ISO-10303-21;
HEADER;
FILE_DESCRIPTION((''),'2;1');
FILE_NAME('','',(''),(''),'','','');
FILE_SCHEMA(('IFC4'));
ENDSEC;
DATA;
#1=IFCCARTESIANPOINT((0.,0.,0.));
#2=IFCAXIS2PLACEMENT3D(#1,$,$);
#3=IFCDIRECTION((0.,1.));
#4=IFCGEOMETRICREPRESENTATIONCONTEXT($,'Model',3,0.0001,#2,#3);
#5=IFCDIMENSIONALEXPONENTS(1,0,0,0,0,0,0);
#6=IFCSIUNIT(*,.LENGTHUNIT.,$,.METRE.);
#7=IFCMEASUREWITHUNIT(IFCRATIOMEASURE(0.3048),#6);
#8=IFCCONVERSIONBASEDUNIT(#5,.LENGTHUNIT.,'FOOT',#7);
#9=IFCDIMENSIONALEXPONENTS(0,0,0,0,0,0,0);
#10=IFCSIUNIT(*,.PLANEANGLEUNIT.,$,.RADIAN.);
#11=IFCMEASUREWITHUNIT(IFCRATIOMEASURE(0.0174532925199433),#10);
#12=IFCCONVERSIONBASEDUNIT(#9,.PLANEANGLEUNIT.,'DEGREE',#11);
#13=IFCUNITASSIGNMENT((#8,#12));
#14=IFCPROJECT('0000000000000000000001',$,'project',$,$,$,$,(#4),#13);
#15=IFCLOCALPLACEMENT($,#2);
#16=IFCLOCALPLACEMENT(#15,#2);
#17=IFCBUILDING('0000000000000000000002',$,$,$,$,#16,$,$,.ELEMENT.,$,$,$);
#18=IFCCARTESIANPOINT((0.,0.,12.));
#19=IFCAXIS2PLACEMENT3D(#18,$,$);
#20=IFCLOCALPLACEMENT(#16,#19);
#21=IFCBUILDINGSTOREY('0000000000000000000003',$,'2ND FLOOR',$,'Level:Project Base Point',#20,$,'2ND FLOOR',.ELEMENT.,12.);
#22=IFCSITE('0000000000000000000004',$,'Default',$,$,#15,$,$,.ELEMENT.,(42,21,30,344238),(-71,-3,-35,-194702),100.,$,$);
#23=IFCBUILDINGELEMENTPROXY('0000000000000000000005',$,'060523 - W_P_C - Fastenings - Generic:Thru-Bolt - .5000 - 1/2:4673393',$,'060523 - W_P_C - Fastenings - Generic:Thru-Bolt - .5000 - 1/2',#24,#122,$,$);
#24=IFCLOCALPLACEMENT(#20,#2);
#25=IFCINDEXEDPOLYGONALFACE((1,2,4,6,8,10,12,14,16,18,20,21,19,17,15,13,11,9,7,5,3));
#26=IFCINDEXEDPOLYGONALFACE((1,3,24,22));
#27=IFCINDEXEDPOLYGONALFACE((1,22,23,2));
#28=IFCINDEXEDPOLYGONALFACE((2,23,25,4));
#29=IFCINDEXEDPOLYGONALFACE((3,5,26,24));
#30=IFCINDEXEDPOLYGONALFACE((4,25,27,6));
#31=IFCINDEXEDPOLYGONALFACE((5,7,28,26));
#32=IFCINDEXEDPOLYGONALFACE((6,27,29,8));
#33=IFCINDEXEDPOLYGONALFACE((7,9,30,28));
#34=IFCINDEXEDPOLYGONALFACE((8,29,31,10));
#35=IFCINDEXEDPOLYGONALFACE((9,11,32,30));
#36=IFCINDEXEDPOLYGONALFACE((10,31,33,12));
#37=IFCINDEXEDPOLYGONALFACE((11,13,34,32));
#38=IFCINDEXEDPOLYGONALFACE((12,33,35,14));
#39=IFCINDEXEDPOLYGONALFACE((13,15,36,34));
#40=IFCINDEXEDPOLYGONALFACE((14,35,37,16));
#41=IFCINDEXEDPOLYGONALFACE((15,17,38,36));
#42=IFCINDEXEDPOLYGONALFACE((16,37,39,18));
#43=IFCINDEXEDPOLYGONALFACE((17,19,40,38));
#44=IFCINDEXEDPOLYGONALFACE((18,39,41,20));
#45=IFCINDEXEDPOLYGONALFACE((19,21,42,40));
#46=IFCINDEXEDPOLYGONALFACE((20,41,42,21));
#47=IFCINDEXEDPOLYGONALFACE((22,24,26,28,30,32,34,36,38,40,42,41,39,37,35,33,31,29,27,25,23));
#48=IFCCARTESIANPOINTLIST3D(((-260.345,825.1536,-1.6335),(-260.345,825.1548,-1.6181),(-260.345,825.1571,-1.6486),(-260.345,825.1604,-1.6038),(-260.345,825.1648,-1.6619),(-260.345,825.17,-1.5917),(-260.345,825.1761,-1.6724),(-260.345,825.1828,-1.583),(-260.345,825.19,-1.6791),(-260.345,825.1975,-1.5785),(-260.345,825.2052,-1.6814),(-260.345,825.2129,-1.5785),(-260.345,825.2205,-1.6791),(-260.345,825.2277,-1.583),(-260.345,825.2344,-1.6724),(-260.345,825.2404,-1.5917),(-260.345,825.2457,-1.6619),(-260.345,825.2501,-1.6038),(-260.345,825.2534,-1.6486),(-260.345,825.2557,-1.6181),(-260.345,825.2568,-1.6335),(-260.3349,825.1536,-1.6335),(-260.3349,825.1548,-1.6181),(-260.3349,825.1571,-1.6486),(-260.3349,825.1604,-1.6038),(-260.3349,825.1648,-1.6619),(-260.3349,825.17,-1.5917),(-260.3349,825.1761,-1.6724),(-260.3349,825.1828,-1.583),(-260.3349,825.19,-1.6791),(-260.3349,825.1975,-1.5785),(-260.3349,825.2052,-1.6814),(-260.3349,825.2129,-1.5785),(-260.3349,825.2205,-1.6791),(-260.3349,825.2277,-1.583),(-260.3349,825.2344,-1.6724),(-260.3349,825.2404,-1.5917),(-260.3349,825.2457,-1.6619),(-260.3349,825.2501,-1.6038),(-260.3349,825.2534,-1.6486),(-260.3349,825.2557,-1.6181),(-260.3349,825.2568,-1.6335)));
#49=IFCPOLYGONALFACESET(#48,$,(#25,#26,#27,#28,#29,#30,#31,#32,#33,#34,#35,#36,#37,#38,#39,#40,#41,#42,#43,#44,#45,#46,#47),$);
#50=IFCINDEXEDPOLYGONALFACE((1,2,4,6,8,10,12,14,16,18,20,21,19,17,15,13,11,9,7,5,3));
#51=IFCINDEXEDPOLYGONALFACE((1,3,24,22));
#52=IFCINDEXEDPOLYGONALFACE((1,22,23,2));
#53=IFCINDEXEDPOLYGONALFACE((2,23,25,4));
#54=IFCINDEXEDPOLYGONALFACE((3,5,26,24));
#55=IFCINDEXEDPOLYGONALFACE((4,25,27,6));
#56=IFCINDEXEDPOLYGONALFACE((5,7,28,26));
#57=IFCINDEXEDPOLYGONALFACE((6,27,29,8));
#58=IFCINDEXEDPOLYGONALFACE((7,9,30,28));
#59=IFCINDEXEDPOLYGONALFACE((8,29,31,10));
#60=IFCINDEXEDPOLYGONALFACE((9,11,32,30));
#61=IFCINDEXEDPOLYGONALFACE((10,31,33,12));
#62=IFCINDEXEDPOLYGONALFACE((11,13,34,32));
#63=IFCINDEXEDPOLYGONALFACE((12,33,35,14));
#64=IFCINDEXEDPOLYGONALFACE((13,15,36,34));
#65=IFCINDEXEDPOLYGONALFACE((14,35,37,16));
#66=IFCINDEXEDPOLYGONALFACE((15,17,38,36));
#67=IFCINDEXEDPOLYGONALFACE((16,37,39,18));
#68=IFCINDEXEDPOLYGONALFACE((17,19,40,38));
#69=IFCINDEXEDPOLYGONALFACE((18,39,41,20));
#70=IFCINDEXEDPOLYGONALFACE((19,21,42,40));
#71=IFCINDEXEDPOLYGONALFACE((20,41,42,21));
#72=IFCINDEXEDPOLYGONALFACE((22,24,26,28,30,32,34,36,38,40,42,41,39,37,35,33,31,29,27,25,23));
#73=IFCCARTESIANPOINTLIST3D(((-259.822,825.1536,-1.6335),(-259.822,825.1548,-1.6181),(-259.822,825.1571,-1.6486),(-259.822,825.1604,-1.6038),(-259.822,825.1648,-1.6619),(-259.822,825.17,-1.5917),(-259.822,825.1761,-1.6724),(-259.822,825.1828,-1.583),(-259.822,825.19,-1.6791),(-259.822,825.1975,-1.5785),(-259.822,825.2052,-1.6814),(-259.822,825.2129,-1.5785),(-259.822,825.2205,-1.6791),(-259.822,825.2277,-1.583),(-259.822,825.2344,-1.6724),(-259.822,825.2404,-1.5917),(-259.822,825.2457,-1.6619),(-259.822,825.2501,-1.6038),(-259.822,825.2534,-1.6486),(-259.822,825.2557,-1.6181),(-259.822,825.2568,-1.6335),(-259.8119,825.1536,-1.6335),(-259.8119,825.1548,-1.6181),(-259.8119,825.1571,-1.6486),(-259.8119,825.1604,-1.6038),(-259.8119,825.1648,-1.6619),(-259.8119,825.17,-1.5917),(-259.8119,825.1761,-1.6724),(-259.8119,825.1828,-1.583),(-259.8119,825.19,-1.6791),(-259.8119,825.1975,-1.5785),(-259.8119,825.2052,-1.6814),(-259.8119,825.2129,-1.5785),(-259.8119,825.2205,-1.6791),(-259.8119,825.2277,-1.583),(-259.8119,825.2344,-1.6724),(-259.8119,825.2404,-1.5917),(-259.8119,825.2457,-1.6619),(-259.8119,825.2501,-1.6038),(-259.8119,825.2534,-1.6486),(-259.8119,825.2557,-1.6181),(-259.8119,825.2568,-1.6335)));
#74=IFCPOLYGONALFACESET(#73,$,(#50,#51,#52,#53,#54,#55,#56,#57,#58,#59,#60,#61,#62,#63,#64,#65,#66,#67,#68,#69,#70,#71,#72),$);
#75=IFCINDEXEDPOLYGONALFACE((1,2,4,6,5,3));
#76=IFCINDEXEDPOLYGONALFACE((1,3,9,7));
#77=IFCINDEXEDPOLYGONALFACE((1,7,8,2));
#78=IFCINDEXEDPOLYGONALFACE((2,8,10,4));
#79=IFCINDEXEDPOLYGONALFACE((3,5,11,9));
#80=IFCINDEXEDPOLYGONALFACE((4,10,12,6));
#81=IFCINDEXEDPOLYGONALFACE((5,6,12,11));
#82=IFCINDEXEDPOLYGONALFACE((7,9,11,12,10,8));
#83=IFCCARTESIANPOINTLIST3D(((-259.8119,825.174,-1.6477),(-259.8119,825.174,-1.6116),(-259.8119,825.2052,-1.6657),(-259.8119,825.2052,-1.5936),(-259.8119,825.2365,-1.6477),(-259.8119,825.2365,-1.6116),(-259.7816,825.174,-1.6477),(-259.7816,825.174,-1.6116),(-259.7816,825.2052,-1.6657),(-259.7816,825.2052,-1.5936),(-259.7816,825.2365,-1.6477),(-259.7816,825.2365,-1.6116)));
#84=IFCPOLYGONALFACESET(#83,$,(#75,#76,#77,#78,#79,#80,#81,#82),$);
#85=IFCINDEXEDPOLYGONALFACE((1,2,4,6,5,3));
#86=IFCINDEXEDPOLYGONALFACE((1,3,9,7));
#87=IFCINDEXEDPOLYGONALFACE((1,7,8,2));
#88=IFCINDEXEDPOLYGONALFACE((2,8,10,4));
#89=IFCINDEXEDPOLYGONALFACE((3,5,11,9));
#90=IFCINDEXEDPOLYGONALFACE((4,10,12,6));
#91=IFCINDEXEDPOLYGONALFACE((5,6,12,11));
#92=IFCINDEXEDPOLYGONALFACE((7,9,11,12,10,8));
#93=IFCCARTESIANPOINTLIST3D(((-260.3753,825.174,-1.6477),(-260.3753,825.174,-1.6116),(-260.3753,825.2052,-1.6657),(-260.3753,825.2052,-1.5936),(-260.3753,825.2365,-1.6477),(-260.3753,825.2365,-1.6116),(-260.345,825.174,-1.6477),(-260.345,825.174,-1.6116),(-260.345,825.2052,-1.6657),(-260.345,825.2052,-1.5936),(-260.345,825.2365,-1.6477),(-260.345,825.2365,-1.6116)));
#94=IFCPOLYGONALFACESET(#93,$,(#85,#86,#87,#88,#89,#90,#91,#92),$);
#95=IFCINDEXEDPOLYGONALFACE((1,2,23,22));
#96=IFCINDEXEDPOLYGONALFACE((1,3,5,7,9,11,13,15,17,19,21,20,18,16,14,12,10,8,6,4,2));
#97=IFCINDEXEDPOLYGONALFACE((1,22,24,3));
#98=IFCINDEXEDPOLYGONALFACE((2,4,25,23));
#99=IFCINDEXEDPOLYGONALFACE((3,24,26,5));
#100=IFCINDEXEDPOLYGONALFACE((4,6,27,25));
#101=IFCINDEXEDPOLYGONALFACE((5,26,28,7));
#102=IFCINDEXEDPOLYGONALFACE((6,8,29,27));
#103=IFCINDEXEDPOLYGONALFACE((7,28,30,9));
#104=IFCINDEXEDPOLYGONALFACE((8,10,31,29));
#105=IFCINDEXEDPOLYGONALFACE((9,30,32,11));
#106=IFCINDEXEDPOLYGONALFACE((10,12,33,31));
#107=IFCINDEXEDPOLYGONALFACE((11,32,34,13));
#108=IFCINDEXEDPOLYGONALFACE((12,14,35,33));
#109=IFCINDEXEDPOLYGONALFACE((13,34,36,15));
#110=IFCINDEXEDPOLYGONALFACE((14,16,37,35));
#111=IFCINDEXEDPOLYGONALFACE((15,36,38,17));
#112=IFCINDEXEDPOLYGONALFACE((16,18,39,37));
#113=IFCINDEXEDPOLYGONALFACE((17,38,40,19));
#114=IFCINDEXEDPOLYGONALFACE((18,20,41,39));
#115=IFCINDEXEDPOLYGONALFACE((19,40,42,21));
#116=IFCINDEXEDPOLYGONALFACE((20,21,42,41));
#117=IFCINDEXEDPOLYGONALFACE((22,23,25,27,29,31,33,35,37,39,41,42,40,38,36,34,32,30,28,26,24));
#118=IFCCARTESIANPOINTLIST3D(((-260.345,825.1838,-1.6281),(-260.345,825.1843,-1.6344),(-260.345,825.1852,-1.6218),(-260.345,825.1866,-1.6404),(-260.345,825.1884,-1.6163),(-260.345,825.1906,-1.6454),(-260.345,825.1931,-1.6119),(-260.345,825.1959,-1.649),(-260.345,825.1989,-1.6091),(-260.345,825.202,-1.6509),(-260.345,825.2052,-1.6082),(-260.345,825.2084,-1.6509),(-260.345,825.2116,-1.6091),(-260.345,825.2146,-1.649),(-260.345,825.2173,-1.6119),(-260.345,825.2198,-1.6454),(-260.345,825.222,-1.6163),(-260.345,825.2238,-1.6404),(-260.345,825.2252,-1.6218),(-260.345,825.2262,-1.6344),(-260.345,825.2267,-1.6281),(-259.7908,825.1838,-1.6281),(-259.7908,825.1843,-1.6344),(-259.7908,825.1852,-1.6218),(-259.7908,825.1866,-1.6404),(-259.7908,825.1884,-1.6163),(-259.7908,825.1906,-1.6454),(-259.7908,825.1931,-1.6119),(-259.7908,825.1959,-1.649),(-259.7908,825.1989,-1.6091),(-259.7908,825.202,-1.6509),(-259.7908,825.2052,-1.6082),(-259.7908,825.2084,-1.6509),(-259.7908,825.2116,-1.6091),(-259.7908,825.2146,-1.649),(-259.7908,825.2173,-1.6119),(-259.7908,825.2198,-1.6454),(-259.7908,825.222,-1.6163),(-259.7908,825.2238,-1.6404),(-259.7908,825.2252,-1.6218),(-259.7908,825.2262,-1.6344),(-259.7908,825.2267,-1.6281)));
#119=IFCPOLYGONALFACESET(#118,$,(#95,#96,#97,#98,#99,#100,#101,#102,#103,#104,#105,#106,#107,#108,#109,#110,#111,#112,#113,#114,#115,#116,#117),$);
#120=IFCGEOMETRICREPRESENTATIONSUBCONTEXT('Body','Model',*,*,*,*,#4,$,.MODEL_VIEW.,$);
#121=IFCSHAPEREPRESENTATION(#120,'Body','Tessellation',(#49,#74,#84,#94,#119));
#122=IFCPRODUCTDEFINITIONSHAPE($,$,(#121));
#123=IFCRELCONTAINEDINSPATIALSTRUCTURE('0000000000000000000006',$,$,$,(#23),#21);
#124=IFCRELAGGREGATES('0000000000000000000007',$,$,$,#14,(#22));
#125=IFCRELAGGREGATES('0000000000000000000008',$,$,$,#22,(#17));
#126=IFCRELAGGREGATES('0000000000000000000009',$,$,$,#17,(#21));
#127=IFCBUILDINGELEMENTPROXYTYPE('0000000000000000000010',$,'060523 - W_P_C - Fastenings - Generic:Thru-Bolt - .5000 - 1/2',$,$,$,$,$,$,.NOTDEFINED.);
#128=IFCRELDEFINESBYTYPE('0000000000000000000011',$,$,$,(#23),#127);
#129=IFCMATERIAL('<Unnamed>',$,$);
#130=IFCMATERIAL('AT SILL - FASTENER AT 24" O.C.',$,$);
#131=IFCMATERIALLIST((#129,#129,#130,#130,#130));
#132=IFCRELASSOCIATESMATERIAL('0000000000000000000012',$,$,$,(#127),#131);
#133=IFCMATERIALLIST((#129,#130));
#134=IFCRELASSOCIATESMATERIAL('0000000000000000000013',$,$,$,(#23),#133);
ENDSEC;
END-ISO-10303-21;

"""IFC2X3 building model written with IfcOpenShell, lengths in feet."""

from ifc_helpers import new_model, entity, si_unit, converted_unit, direction, frame, frame_2d, origin, place, context, subcontext, project, spatial, polyline, circle, outline, extrude, source, transform, mapped, material, material_list, type_object, type_shapes, element, save


model = new_model("IFC2X3")

# Units and contexts
model_context = context("Model", 3, precision=0.0001, world=origin(), true_north=direction((0.0, 1.0)))
body_context = subcontext(model_context, "Body", "Model", "MODEL_VIEW")
ifc_project = project(units=[converted_unit("LENGTHUNIT", "FOOT", entity("IfcRatioMeasure", 0.3048), si_unit("LENGTHUNIT", "METRE"), dimensions=[1, 0, 0, 0, 0, 0, 0]), converted_unit("PLANEANGLEUNIT", "DEGREE", entity("IfcRatioMeasure", 0.0174532925199433), si_unit("PLANEANGLEUNIT", "RADIAN"), dimensions=[0, 0, 0, 0, 0, 0, 0])], contexts=[model_context])

# Site, building, storey
site_placement = place(None, origin())
site = spatial("IfcSite", under=ifc_project, at=site_placement, Name="Default", CompositionType="ELEMENT", RefLatitude=(42, 21, 30, 344238), RefLongitude=(-71, -3, -35, -194702), RefElevation=100.0)
building_placement = place(site_placement, origin())
building = spatial("IfcBuilding", under=site, at=building_placement, CompositionType="ELEMENT")
storey_placement = place(building_placement, frame((0.0, 0.0, 12.0)))
storey = spatial("IfcBuildingStorey", under=building, at=storey_placement, Name="2ND FLOOR", ObjectType="Level:Project Base Point", LongName="2ND FLOOR", CompositionType="ELEMENT", Elevation=12.0)

# Building element proxy
ifc_material_1 = material(Name="<Unnamed>")
ifc_material_2 = material(Name="AT SILL - FASTENER AT 24\" O.C.")
ifc_material_list_1 = material_list([ifc_material_1, ifc_material_1, ifc_material_2, ifc_material_2, ifc_material_2])
building_element_proxy_type_1 = type_object("IfcBuildingElementProxyType", Name="060523 - W_P_C - Fastenings - Generic:Thru-Bolt - .5000 - 1/2", PredefinedType="NOTDEFINED", material=ifc_material_list_1)
shared_shape_1 = source(origin(), body_context, "Body", "SweptSolid", [
    extrude(circle(Radius=0.0518, at=frame_2d((0.0, 0.0), x_axis=(1.0, 0.0))), frame((0.0, 0.0, 0.0), z_axis=(0.0, 0.0, 1.0), x_axis=(0.0, -1.0, 0.0)), (0.0, 0.0, 1.0), 0.0101),
    extrude(circle(Radius=0.0518, at=frame_2d((0.0, 0.0), x_axis=(1.0, 0.0))), frame((0.0, 0.0, -0.523), z_axis=(0.0, 0.0, 1.0), x_axis=(0.0, -1.0, 0.0)), (0.0, 0.0, 1.0), 0.0101),
    extrude(outline(polyline([(-0.018, -0.0313), (0.018, -0.0313), (0.0361, 0.0), (0.018, 0.0312), (-0.018, 0.0312), (-0.0361, 0.0), (-0.018, -0.0313)])), frame((0.0, 0.0, -0.5533), z_axis=(0.0, 0.0, 1.0), x_axis=(0.866025, -0.5, 0.0)), (0.0, 0.0, 1.0), 0.0303),
    extrude(outline(polyline([(-0.018, -0.0313), (0.018, -0.0313), (0.0361, 0.0), (0.018, 0.0313), (-0.018, 0.0313), (-0.0361, 0.0), (-0.018, -0.0313)])), frame((0.0, 0.0, 0.0101), z_axis=(0.0, 0.0, 1.0), x_axis=(0.0, -1.0, 0.0)), (0.0, 0.0, 1.0), 0.0303),
    extrude(circle(Radius=0.0215, at=frame_2d((0.0, 0.0), x_axis=(1.0, 0.0))), frame((0.0, 0.0, -0.5442), z_axis=(0.0, 0.0, 1.0), x_axis=(0.0, 1.0, 0.0)), (0.0, 0.0, 1.0), 0.5543),
])
type_shapes(building_element_proxy_type_1, [shared_shape_1])
ifc_material_list_2 = material_list([ifc_material_1, ifc_material_2])
proxy_1_placement = place(storey_placement, frame((-260.3349, 825.2052, -1.6297), z_axis=(-1.0, 0.0, 0.0), x_axis=(0.0, -1.0, 0.0)))
element("IfcBuildingElementProxy", 1, at=proxy_1_placement, inside=storey, type_object=building_element_proxy_type_1, material=ifc_material_list_2, Name="060523 - W_P_C - Fastenings - Generic:Thru-Bolt - .5000 - 1/2:4673393", ObjectType="060523 - W_P_C - Fastenings - Generic:Thru-Bolt - .5000 - 1/2", context=body_context, shape_type="MappedRepresentation", body=[
    mapped(shared_shape_1, transform((0.0, 0.0, 0.0), scale=1.0)),
])

save(model, "model.ifc")
